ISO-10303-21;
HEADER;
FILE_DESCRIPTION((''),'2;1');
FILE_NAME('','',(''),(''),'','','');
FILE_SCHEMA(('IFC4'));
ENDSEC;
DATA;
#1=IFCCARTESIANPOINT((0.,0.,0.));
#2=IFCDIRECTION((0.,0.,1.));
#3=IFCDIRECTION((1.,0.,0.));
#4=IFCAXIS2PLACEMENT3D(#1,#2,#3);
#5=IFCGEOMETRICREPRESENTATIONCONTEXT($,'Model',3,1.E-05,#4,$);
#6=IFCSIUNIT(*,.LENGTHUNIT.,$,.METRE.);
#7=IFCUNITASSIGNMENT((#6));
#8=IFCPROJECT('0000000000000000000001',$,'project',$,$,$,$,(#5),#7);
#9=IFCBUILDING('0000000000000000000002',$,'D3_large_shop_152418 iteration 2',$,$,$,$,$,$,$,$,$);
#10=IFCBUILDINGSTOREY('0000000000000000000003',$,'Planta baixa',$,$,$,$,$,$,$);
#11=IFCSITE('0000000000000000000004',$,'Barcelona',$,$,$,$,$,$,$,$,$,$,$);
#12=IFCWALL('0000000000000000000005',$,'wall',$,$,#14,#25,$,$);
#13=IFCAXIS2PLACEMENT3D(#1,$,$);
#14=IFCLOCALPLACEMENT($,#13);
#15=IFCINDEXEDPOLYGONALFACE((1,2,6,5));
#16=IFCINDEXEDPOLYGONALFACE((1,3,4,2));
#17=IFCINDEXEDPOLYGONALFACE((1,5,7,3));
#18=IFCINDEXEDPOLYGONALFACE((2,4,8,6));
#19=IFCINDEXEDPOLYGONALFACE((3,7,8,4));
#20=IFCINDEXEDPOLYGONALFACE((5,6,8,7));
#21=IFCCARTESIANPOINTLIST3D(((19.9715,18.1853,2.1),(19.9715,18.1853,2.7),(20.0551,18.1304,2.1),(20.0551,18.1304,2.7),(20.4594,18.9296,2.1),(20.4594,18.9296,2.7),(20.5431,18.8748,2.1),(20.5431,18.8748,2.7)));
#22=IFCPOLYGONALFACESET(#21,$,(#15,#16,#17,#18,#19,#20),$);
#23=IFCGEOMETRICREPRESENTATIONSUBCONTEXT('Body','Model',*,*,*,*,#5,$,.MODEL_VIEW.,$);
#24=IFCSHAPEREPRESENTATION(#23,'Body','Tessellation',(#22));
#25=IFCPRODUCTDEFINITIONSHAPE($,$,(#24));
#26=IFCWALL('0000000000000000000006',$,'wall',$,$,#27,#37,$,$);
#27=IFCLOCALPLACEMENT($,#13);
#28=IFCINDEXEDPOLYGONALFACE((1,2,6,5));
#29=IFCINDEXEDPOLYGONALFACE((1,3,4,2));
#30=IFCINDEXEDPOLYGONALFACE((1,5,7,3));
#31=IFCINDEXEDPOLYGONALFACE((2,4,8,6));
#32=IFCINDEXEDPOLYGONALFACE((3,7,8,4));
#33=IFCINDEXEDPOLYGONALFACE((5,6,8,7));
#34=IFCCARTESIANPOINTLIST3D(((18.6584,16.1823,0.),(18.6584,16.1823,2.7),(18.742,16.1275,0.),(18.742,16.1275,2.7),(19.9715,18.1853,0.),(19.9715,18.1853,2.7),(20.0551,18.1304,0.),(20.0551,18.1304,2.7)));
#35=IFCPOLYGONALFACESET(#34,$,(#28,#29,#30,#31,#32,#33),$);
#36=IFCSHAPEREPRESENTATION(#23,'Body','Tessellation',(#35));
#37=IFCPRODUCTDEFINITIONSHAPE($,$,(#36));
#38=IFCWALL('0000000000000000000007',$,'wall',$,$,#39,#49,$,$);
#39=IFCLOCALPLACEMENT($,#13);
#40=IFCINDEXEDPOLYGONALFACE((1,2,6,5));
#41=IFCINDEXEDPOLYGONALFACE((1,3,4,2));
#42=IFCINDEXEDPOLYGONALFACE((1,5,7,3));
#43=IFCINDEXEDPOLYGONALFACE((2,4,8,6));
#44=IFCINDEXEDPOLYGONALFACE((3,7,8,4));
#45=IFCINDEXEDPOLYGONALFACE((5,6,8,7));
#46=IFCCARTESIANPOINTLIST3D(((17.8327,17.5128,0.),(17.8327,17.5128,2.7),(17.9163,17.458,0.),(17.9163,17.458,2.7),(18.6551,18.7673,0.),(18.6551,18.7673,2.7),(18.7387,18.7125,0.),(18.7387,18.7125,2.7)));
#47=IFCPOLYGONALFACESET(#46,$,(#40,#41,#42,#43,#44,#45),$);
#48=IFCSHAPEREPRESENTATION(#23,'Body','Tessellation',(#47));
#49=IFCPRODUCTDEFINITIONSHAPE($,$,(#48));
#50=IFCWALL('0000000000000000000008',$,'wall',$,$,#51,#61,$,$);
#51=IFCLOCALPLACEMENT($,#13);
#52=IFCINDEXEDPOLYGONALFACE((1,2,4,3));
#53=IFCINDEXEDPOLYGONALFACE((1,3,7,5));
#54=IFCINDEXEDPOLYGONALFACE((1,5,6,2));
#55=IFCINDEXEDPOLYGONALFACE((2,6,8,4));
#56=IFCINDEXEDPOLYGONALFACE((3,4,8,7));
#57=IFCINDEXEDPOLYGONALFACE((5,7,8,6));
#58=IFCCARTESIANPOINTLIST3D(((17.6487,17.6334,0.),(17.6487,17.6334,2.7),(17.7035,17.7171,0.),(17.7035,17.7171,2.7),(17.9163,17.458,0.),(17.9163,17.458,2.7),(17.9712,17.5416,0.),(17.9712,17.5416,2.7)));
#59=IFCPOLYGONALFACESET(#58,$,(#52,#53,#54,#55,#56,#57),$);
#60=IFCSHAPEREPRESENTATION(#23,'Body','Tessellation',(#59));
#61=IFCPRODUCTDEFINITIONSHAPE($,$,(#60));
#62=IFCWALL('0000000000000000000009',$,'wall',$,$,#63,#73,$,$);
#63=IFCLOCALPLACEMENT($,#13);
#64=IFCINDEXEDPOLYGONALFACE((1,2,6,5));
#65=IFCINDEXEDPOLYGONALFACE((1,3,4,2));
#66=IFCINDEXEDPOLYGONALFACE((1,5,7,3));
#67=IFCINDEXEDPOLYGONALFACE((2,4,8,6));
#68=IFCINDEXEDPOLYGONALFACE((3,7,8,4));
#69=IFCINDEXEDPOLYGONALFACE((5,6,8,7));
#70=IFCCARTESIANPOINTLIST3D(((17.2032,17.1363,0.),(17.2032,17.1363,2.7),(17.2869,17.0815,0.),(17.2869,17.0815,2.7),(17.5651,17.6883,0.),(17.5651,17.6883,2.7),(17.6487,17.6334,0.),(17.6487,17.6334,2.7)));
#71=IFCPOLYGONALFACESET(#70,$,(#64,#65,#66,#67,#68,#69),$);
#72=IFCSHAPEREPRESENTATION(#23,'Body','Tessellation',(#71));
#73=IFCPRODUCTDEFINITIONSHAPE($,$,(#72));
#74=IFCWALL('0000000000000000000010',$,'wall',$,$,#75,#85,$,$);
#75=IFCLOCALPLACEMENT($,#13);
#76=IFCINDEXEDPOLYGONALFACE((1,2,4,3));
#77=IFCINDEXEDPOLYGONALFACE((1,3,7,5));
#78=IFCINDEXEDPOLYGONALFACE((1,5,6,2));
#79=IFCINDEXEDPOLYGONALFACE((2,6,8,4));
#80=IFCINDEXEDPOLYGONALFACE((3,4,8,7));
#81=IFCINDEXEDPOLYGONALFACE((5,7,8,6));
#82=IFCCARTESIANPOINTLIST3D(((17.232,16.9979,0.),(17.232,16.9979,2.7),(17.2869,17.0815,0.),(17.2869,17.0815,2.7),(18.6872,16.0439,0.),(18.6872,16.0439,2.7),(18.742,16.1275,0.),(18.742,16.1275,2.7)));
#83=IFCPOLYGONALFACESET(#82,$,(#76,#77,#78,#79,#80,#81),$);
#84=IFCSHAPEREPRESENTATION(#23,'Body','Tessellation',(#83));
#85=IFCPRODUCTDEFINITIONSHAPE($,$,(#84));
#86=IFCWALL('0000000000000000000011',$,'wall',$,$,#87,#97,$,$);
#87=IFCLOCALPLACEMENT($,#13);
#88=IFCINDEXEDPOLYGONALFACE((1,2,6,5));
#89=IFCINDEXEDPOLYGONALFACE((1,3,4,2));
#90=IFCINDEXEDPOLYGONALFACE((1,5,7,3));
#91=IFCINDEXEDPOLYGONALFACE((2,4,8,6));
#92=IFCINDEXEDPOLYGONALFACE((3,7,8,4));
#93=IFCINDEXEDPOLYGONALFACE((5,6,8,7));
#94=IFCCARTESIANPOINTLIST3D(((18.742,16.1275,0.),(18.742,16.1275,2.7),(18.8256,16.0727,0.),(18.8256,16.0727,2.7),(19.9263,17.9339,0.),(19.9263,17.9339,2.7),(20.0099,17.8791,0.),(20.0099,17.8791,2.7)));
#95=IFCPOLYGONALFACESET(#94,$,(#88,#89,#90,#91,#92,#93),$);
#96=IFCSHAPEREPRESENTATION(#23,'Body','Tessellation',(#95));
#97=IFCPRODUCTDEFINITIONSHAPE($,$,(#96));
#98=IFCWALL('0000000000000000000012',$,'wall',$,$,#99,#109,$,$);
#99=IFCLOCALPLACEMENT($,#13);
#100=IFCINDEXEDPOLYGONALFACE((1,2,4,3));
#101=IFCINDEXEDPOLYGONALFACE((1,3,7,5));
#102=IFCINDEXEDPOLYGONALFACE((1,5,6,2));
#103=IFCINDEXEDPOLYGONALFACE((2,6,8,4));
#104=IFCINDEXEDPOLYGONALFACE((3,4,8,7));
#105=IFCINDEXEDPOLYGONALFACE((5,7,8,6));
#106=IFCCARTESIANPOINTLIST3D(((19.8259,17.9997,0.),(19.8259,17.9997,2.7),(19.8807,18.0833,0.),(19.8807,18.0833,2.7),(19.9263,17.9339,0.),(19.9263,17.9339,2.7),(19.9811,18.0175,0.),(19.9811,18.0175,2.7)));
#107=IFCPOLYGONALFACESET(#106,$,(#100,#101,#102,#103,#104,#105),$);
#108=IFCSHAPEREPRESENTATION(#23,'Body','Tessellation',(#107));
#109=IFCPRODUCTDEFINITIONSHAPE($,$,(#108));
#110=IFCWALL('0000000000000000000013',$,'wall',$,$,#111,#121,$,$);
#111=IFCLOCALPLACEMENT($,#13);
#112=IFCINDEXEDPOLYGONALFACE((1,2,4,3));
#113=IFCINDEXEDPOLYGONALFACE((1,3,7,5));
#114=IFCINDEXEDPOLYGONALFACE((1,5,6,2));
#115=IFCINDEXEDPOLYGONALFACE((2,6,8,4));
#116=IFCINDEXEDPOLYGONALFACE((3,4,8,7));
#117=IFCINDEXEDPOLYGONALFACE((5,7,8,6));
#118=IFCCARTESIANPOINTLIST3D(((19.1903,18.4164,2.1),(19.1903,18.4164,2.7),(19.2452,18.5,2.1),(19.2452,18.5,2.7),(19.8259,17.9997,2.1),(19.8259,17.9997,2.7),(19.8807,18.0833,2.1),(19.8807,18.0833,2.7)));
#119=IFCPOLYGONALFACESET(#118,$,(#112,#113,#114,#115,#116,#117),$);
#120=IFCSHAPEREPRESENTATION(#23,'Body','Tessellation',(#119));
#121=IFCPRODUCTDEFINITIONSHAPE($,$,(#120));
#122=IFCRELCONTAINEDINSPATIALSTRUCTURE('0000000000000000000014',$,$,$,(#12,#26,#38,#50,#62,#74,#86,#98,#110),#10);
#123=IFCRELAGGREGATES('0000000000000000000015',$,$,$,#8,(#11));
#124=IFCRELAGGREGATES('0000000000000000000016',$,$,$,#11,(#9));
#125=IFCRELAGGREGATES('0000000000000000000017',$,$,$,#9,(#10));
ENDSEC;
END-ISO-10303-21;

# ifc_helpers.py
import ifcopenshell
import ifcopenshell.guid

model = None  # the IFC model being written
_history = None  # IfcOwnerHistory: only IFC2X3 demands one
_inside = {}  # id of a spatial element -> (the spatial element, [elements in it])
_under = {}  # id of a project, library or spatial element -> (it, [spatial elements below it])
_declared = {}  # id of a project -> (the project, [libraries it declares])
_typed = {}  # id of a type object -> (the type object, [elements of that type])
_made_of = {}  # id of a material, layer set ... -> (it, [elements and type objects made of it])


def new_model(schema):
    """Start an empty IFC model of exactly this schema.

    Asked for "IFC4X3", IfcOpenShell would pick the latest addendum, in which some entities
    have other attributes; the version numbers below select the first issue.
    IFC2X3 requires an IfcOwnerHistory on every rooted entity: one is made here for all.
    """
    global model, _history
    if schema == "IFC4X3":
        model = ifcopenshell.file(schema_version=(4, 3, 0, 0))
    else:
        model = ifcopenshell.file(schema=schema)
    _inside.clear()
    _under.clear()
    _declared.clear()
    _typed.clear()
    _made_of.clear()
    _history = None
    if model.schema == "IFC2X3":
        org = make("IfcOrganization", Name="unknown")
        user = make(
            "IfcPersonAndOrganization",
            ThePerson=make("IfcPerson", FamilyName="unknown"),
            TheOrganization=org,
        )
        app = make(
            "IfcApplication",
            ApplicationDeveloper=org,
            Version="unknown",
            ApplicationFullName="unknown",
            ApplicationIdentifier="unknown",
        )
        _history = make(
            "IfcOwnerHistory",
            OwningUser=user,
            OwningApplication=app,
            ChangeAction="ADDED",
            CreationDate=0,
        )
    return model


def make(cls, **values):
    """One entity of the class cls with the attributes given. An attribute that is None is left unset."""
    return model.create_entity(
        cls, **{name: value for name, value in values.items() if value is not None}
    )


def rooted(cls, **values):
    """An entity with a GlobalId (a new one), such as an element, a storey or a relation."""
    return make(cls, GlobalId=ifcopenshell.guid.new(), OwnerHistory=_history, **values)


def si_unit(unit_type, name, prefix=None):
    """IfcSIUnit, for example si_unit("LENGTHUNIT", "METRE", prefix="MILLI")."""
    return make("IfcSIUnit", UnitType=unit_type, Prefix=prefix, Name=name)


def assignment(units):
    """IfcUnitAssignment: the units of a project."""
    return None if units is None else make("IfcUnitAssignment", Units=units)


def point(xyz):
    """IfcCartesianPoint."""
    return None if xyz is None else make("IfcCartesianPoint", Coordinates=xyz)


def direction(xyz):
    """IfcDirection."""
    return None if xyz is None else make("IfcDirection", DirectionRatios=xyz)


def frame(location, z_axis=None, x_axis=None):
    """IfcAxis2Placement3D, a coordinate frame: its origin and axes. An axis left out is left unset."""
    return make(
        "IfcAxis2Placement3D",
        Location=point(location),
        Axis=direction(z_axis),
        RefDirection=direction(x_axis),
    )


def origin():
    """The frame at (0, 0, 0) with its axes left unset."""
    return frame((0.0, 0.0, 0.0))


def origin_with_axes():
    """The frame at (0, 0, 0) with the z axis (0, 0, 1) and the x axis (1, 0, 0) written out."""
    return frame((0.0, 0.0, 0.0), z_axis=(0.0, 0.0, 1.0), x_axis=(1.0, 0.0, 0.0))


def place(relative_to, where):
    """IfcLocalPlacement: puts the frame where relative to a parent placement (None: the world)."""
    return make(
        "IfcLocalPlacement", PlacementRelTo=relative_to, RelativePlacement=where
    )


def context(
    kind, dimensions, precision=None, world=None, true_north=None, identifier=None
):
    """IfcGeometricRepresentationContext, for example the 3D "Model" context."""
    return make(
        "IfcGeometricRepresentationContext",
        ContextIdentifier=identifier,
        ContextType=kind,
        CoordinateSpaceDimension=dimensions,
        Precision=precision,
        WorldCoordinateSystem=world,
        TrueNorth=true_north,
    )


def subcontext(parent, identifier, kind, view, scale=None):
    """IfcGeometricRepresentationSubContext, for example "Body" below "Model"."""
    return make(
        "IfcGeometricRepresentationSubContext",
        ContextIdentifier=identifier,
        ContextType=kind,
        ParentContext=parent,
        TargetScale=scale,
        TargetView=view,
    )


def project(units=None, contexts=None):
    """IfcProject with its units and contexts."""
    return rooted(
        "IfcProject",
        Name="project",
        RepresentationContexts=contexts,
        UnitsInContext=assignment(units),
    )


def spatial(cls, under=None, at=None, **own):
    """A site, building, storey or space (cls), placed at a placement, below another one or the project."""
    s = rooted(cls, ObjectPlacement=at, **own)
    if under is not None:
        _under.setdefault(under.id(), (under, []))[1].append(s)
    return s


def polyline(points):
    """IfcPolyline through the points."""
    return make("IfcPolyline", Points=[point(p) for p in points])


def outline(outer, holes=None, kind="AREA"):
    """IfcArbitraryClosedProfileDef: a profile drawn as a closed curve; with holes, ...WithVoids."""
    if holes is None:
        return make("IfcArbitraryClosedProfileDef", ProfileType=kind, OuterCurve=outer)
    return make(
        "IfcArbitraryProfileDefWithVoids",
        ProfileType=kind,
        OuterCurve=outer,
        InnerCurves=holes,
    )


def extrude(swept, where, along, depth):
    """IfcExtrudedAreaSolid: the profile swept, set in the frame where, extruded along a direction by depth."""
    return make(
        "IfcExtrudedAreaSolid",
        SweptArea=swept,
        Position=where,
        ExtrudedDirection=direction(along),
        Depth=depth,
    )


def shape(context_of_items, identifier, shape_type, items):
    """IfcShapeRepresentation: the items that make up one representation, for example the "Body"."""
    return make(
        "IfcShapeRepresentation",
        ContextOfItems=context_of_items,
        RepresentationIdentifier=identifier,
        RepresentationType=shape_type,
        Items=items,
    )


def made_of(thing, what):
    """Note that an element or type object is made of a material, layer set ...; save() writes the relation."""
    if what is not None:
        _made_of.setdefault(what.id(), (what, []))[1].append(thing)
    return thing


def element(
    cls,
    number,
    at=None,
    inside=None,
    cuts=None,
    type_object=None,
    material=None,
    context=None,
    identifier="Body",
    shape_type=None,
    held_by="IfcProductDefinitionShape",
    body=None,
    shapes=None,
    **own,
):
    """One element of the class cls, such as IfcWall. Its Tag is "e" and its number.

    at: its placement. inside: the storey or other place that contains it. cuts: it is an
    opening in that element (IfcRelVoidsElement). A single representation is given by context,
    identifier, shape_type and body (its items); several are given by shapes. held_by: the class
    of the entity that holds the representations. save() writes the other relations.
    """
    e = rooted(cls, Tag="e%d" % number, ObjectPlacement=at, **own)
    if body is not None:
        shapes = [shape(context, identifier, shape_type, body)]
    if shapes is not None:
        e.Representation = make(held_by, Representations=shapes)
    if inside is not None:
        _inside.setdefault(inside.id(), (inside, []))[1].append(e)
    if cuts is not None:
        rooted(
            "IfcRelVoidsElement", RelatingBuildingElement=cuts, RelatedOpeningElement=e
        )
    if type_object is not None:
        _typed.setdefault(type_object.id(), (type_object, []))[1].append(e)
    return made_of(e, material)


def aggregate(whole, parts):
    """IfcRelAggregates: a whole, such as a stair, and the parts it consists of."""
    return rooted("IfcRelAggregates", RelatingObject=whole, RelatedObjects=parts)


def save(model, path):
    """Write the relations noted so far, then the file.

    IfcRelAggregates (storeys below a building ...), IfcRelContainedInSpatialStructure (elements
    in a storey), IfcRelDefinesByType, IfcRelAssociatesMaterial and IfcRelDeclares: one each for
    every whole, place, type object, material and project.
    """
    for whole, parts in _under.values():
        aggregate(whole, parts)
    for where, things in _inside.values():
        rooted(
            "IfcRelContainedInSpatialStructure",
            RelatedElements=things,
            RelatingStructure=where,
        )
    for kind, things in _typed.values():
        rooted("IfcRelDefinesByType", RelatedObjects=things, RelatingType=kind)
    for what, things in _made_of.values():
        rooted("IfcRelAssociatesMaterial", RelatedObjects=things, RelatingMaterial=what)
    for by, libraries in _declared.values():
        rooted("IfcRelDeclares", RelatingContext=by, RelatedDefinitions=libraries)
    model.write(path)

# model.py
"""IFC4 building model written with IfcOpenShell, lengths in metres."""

from ifc_helpers import new_model, si_unit, frame, origin, origin_with_axes, place, context, subcontext, project, spatial, polyline, outline, extrude, element, save


model = new_model("IFC4")

# Units and contexts
model_context = context("Model", 3, precision=1e-05, world=origin_with_axes())
body_context = subcontext(model_context, "Body", "Model", "MODEL_VIEW")
ifc_project = project(units=[si_unit("LENGTHUNIT", "METRE")], contexts=[model_context])

# Site, building, storey
site = spatial("IfcSite", under=ifc_project, Name="Barcelona")
building = spatial("IfcBuilding", under=site, Name="D3_large_shop_152418 iteration 2")
storey = spatial("IfcBuildingStorey", under=building, Name="Planta baixa")

# Walls
wall_1_placement = place(None, origin_with_axes())
element("IfcWall", 1, at=wall_1_placement, inside=storey, Name="wall", context=body_context, shape_type="SweptSolid", body=[
    extrude(outline(polyline([(20.5431, 18.8748), (20.0551, 18.1304), (19.9715, 18.1853), (20.4594, 18.9296), (20.5431, 18.8748)])), frame((0.0, 0.0, 2.1)), (0.0, 0.0, 1.0), 0.6),
])
wall_2_placement = place(None, origin_with_axes())
element("IfcWall", 2, at=wall_2_placement, inside=storey, Name="wall", context=body_context, shape_type="SweptSolid", body=[
    extrude(outline(polyline([(20.0551, 18.1304), (18.742, 16.1275), (18.6584, 16.1823), (19.9715, 18.1853), (20.0551, 18.1304)])), origin(), (0.0, 0.0, 1.0), 2.7),
])
wall_3_placement = place(None, origin_with_axes())
element("IfcWall", 3, at=wall_3_placement, inside=storey, Name="wall", context=body_context, shape_type="SweptSolid", body=[
    extrude(outline(polyline([(18.7387, 18.7125), (17.9163, 17.458), (17.8327, 17.5128), (18.6551, 18.7673), (18.7387, 18.7125)])), origin(), (0.0, 0.0, 1.0), 2.7),
])
wall_4_placement = place(None, origin_with_axes())
element("IfcWall", 4, at=wall_4_placement, inside=storey, Name="wall", context=body_context, shape_type="SweptSolid", body=[
    extrude(outline(polyline([(17.9163, 17.458), (17.6487, 17.6334), (17.7035, 17.7171), (17.9712, 17.5416), (17.9163, 17.458)])), origin(), (0.0, 0.0, 1.0), 2.7),
])
wall_5_placement = place(None, origin_with_axes())
element("IfcWall", 5, at=wall_5_placement, inside=storey, Name="wall", context=body_context, shape_type="SweptSolid", body=[
    extrude(outline(polyline([(17.6487, 17.6334), (17.2869, 17.0815), (17.2032, 17.1363), (17.5651, 17.6883), (17.6487, 17.6334)])), origin(), (0.0, 0.0, 1.0), 2.7),
])
wall_6_placement = place(None, origin_with_axes())
element("IfcWall", 6, at=wall_6_placement, inside=storey, Name="wall", context=body_context, shape_type="SweptSolid", body=[
    extrude(outline(polyline([(17.2869, 17.0815), (18.742, 16.1275), (18.6872, 16.0439), (17.232, 16.9979), (17.2869, 17.0815)])), origin(), (0.0, 0.0, 1.0), 2.7),
])
wall_7_placement = place(None, origin_with_axes())
element("IfcWall", 7, at=wall_7_placement, inside=storey, Name="wall", context=body_context, shape_type="SweptSolid", body=[
    extrude(outline(polyline([(18.742, 16.1275), (19.9263, 17.9339), (20.0099, 17.8791), (18.8256, 16.0727), (18.742, 16.1275)])), origin(), (0.0, 0.0, 1.0), 2.7),
])
wall_8_placement = place(None, origin_with_axes())
element("IfcWall", 8, at=wall_8_placement, inside=storey, Name="wall", context=body_context, shape_type="SweptSolid", body=[
    extrude(outline(polyline([(19.9263, 17.9339), (19.8259, 17.9997), (19.8807, 18.0833), (19.9811, 18.0175), (19.9263, 17.9339)])), origin(), (0.0, 0.0, 1.0), 2.7),
])
wall_9_placement = place(None, origin_with_axes())
element("IfcWall", 9, at=wall_9_placement, inside=storey, Name="wall", context=body_context, shape_type="SweptSolid", body=[
    extrude(outline(polyline([(19.8259, 17.9997), (19.1903, 18.4164), (19.2452, 18.5), (19.8807, 18.0833), (19.8259, 17.9997)])), frame((0.0, 0.0, 2.1)), (0.0, 0.0, 1.0), 0.6),
])

save(model, "model.ifc")
